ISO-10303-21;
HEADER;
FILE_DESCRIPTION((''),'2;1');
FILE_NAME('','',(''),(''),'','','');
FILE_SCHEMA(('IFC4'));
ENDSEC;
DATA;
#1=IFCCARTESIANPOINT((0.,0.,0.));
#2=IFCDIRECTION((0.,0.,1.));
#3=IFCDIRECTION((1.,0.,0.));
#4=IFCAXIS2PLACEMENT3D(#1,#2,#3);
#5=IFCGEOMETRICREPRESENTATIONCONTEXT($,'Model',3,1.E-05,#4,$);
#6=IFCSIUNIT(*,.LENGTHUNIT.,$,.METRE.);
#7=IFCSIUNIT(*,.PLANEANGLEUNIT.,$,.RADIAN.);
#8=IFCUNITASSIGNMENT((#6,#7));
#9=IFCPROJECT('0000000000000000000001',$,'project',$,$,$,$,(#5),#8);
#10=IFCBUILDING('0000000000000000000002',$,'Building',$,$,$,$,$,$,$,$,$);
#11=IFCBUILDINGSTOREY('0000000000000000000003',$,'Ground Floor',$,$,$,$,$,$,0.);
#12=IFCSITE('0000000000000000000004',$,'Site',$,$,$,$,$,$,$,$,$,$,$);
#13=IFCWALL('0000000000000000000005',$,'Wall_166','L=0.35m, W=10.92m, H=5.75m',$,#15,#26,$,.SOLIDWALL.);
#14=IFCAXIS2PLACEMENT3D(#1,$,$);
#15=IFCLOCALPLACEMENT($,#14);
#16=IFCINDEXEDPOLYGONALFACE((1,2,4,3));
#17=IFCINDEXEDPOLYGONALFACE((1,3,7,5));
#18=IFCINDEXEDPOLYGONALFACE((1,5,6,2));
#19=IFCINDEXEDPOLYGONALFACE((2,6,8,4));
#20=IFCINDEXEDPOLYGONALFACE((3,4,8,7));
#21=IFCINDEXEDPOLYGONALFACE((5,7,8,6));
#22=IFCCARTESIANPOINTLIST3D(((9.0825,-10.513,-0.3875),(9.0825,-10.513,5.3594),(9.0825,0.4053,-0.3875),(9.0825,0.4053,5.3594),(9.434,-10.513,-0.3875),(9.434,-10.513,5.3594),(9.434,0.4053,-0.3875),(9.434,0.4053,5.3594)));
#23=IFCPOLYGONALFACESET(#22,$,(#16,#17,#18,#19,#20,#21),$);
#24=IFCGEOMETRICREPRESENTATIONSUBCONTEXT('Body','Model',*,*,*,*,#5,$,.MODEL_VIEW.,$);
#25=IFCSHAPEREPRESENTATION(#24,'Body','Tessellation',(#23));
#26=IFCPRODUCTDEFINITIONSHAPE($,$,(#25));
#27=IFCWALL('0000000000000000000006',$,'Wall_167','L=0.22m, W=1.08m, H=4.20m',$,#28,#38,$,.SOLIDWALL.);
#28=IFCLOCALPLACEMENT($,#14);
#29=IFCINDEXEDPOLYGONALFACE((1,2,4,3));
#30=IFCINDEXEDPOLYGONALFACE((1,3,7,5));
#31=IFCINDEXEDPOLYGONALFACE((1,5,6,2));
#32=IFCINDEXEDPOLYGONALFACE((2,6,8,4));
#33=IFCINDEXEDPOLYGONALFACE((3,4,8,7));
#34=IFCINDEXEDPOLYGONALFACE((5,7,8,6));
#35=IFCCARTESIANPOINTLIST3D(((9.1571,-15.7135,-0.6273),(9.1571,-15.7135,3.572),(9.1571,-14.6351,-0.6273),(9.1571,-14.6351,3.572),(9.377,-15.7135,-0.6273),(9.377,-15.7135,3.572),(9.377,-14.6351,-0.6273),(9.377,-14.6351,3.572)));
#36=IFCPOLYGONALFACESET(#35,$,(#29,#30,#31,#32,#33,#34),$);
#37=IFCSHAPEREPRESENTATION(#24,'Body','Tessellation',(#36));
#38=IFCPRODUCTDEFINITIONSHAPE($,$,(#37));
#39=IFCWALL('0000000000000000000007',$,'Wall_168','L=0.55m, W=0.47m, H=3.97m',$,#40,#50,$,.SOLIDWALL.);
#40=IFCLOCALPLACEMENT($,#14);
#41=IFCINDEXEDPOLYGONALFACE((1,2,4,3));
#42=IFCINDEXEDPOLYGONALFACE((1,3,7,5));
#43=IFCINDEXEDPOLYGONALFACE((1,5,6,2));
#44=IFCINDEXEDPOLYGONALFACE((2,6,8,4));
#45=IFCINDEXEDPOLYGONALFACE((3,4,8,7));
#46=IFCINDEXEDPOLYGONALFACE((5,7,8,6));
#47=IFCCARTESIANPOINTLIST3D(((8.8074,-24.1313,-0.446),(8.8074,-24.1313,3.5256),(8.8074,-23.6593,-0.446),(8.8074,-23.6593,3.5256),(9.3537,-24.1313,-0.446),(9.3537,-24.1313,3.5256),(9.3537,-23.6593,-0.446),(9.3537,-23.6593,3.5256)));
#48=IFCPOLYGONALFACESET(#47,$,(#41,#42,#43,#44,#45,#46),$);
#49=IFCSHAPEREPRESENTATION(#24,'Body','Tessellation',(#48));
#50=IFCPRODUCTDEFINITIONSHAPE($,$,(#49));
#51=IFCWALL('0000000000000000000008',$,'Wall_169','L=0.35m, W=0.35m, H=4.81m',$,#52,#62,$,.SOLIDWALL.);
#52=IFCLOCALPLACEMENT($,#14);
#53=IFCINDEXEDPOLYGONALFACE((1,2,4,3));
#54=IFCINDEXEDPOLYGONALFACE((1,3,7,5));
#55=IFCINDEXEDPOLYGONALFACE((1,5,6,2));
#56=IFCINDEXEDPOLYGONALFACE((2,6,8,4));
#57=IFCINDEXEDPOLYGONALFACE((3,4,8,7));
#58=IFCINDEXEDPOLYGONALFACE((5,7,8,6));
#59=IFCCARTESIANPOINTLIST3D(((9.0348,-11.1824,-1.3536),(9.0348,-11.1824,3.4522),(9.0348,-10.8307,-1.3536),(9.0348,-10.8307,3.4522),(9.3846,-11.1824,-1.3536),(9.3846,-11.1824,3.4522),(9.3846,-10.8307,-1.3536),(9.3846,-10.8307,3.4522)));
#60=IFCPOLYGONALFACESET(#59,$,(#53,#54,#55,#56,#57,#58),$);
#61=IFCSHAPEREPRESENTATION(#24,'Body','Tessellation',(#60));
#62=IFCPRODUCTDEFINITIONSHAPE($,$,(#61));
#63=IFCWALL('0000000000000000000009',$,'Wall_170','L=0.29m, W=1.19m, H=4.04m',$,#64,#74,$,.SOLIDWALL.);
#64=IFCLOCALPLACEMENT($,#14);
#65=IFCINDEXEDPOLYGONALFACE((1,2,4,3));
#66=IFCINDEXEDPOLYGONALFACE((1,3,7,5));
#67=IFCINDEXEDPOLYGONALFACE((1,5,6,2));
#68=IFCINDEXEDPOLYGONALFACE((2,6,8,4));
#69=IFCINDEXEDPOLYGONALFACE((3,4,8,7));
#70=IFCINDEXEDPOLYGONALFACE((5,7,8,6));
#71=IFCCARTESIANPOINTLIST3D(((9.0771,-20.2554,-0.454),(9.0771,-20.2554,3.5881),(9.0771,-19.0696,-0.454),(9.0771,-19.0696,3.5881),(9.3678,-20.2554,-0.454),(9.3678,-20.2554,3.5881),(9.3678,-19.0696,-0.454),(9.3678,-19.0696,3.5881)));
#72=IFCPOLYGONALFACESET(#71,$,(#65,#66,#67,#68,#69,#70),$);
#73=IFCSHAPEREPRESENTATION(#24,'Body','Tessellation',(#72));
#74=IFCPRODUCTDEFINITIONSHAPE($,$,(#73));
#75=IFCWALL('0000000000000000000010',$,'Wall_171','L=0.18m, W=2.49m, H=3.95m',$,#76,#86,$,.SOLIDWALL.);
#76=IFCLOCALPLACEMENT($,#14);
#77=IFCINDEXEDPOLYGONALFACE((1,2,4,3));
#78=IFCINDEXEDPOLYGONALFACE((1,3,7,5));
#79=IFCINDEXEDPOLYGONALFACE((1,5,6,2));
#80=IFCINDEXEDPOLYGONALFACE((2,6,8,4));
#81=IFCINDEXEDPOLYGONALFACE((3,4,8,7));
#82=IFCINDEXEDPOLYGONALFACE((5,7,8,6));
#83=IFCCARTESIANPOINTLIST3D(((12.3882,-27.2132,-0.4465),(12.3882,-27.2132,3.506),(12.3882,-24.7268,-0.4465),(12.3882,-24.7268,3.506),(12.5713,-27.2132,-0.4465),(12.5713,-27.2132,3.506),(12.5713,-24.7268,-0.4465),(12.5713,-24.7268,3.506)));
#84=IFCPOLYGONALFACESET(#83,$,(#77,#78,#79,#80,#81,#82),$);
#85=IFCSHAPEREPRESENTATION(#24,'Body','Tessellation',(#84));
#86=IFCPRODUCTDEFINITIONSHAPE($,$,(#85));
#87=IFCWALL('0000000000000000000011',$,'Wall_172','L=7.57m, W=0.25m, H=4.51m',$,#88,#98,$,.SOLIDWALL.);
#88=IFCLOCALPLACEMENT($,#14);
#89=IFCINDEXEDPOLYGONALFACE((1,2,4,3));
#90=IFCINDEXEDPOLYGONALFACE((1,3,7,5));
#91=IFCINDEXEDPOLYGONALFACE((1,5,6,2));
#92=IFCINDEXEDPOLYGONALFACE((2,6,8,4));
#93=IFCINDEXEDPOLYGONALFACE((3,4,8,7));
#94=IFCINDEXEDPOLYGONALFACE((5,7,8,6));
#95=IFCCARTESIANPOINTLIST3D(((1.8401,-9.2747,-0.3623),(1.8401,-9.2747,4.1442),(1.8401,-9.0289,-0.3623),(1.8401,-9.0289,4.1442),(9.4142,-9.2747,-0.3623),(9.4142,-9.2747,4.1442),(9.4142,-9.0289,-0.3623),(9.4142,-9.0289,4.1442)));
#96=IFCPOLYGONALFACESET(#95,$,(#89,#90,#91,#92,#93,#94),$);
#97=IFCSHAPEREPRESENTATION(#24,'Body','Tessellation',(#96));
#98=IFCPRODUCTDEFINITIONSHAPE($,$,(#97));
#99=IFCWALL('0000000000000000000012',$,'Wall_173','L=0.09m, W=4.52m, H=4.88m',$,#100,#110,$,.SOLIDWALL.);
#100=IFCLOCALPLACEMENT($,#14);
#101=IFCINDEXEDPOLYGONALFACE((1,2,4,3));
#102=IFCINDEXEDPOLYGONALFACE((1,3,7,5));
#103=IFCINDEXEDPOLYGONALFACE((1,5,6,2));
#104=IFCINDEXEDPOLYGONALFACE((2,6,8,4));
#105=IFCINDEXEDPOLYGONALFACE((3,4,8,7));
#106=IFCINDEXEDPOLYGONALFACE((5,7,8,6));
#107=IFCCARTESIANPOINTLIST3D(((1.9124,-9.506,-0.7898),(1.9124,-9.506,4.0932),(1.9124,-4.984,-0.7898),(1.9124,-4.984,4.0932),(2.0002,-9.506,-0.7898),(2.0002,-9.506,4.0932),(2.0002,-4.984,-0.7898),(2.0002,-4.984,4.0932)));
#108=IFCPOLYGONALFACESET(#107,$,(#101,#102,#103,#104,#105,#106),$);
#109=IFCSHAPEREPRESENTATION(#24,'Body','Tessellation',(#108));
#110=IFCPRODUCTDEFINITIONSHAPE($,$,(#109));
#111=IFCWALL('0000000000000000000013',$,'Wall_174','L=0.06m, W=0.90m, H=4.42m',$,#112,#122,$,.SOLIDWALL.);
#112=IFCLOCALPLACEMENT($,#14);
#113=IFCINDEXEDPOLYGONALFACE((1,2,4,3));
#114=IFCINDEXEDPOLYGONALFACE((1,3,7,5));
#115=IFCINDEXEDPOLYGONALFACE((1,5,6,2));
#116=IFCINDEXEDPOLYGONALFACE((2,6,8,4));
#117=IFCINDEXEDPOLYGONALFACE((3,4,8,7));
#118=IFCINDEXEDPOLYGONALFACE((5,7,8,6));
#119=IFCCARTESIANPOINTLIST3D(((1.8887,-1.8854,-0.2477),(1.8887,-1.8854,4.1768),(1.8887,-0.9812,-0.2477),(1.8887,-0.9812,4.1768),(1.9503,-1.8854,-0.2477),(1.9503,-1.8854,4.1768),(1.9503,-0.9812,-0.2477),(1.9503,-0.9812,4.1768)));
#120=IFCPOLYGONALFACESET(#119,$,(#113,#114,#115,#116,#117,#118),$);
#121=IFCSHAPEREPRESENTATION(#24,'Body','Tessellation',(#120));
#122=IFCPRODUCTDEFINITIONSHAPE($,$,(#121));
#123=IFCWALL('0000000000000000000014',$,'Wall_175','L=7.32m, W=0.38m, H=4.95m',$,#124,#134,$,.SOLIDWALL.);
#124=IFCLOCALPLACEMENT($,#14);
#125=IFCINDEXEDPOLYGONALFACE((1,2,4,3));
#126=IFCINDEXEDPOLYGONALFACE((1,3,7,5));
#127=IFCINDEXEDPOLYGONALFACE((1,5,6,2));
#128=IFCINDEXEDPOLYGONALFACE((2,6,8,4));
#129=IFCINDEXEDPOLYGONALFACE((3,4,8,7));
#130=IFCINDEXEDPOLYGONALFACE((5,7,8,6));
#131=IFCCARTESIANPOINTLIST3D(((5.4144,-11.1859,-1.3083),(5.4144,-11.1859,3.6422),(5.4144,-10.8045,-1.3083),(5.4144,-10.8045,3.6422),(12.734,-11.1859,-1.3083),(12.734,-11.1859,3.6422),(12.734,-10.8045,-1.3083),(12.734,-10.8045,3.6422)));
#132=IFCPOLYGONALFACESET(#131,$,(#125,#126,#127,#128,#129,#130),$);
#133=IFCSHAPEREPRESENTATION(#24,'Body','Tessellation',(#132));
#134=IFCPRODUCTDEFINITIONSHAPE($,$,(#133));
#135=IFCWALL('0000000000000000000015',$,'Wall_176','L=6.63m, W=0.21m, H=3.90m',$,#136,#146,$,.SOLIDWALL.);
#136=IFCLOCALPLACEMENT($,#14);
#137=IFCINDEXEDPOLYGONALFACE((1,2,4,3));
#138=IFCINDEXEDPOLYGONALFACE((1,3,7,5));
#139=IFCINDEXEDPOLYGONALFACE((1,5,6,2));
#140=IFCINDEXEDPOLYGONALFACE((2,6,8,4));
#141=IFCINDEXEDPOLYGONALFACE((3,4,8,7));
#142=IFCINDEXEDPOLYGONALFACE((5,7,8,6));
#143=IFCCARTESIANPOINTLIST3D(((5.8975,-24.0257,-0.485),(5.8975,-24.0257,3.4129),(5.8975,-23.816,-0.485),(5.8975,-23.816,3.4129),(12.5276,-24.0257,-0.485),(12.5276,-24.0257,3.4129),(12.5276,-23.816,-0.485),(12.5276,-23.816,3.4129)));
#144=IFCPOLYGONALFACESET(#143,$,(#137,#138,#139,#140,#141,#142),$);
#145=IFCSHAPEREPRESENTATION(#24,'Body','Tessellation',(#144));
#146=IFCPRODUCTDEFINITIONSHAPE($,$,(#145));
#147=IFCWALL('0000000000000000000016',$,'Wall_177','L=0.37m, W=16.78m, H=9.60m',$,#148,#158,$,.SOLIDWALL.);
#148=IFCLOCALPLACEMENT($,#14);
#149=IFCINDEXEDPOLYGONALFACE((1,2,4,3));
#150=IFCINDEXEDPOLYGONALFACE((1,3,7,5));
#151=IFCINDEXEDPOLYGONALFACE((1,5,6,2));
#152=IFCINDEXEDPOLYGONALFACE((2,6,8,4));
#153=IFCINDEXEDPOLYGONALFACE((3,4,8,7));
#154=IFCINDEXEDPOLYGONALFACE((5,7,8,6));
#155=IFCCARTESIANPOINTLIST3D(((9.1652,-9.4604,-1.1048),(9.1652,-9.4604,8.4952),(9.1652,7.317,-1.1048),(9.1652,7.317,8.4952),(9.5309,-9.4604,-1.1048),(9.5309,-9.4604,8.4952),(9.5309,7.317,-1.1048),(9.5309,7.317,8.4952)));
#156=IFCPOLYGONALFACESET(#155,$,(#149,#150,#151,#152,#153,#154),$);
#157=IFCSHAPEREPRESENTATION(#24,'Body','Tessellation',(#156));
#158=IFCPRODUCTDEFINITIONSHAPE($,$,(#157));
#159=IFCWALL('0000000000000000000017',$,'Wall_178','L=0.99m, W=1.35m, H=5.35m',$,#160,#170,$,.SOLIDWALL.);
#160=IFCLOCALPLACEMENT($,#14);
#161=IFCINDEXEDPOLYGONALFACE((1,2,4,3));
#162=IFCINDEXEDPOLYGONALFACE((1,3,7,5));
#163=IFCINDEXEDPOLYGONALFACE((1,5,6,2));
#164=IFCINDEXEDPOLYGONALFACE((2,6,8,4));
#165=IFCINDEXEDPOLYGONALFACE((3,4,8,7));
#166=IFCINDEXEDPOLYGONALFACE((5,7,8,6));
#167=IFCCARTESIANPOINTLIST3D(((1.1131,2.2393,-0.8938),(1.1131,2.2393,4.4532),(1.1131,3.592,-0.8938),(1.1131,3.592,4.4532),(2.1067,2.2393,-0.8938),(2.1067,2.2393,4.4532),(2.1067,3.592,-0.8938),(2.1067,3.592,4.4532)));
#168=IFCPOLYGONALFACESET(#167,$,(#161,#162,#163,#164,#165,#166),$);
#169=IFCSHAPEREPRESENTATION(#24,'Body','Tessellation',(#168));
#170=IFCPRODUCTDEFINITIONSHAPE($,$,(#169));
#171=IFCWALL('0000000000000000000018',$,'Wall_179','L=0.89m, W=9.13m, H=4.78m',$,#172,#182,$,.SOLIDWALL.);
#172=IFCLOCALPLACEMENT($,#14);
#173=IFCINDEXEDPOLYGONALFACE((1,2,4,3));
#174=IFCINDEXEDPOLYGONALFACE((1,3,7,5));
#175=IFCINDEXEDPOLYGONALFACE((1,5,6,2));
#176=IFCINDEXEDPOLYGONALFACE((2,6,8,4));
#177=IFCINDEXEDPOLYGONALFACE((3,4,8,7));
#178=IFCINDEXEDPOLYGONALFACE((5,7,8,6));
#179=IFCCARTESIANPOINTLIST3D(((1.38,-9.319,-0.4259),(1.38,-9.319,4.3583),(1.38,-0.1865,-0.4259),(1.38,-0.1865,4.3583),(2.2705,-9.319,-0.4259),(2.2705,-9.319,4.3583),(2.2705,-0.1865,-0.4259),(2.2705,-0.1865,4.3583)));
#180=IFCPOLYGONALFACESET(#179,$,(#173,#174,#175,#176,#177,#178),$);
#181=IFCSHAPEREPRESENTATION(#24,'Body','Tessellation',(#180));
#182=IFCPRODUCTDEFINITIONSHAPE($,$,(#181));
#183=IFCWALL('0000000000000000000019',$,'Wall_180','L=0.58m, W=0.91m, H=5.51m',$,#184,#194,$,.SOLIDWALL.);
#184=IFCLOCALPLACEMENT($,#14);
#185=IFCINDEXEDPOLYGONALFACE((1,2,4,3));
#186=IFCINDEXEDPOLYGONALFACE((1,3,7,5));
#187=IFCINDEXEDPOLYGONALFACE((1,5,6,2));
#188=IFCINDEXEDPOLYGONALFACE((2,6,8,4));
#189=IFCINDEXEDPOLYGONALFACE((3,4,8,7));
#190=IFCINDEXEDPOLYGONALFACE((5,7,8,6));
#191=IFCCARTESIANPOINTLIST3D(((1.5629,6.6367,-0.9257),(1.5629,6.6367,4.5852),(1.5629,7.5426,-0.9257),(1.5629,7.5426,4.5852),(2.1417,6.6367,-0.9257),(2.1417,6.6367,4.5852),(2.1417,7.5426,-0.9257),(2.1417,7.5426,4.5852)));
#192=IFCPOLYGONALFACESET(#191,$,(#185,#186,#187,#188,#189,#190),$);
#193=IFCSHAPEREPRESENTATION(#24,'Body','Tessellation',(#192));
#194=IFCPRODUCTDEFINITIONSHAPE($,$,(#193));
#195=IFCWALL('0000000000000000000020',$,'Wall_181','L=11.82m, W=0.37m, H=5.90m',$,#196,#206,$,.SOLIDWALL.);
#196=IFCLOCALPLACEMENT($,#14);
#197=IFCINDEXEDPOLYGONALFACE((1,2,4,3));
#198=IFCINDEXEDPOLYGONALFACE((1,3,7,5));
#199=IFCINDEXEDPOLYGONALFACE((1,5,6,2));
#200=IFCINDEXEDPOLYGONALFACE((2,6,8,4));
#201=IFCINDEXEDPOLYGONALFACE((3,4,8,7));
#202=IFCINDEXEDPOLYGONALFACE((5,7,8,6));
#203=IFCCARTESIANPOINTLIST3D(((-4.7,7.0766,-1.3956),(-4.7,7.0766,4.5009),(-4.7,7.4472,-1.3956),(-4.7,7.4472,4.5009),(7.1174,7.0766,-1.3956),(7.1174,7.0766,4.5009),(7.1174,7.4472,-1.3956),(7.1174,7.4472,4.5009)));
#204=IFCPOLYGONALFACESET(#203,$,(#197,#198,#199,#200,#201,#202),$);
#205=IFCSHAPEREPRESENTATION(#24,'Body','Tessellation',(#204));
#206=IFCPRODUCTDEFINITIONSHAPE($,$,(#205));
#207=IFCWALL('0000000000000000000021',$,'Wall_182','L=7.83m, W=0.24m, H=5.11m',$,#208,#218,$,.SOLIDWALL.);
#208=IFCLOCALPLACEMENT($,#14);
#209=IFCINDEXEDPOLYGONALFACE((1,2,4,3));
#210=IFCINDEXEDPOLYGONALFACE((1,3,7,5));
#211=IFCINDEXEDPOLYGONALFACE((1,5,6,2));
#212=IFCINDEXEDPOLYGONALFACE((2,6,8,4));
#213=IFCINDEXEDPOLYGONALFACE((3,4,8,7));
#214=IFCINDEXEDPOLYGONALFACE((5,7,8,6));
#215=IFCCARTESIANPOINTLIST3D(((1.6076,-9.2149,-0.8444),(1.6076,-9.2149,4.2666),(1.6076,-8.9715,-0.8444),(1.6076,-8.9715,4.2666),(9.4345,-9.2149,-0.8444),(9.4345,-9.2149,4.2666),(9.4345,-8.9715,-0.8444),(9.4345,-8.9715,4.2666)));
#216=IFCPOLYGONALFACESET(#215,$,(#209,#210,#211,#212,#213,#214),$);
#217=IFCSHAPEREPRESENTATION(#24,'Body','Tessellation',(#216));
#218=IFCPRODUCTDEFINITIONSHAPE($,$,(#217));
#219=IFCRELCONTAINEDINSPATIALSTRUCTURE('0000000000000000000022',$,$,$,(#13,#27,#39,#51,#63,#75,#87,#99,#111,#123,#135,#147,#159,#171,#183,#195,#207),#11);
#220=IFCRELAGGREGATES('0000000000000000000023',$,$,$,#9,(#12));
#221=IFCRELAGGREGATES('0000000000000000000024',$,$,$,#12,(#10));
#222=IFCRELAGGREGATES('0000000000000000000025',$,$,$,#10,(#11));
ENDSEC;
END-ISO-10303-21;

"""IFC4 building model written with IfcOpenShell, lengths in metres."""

from ifc_helpers import new_model, si_unit, frame, origin_with_axes, origin_2d, context, subcontext, project, spatial, rectangle, extrude, element, save


model = new_model("IFC4")

# Units and contexts
model_context = context("Model", 3, precision=1e-05, world=origin_with_axes())
body_context = subcontext(model_context, "Body", "Model", "MODEL_VIEW")
ifc_project = project(units=[si_unit("LENGTHUNIT", "METRE"), si_unit("PLANEANGLEUNIT", "RADIAN")], contexts=[model_context])

# Site, building, storey
site = spatial("IfcSite", under=ifc_project, Name="Site")
building = spatial("IfcBuilding", under=site, Name="Building")
storey = spatial("IfcBuildingStorey", under=building, Name="Ground Floor", Elevation=0.0)

# Walls
element("IfcWall", 1, inside=storey, Name="Wall_166", Description="L=0.35m, W=10.92m, H=5.75m", PredefinedType="SOLIDWALL", context=body_context, shape_type="SweptSolid", body=[
    extrude(rectangle(XDim=0.3516, YDim=10.9184, at=origin_2d()), frame((9.2583, -5.0538, -0.3875), z_axis=(0.0, 0.0, 1.0), x_axis=(1.0, 0.0, 0.0)), (0.0, 0.0, 1.0), 5.747),
])
element("IfcWall", 2, inside=storey, Name="Wall_167", Description="L=0.22m, W=1.08m, H=4.20m", PredefinedType="SOLIDWALL", context=body_context, shape_type="SweptSolid", body=[
    extrude(rectangle(XDim=0.2199, YDim=1.0784, at=origin_2d()), frame((9.267, -15.1743, -0.6273), z_axis=(0.0, 0.0, 1.0), x_axis=(1.0, 0.0, 0.0)), (0.0, 0.0, 1.0), 4.1993),
])
element("IfcWall", 3, inside=storey, Name="Wall_168", Description="L=0.55m, W=0.47m, H=3.97m", PredefinedType="SOLIDWALL", context=body_context, shape_type="SweptSolid", body=[
    extrude(rectangle(XDim=0.5463, YDim=0.472, at=origin_2d()), frame((9.0806, -23.8953, -0.446), z_axis=(0.0, 0.0, 1.0), x_axis=(1.0, 0.0, 0.0)), (0.0, 0.0, 1.0), 3.9716),
])
element("IfcWall", 4, inside=storey, Name="Wall_169", Description="L=0.35m, W=0.35m, H=4.81m", PredefinedType="SOLIDWALL", context=body_context, shape_type="SweptSolid", body=[
    extrude(rectangle(XDim=0.3497, YDim=0.3517, at=origin_2d()), frame((9.2097, -11.0066, -1.3536), z_axis=(0.0, 0.0, 1.0), x_axis=(1.0, 0.0, 0.0)), (0.0, 0.0, 1.0), 4.8058),
])
element("IfcWall", 5, inside=storey, Name="Wall_170", Description="L=0.29m, W=1.19m, H=4.04m", PredefinedType="SOLIDWALL", context=body_context, shape_type="SweptSolid", body=[
    extrude(rectangle(XDim=0.2907, YDim=1.1858, at=origin_2d()), frame((9.2224, -19.6625, -0.454), z_axis=(0.0, 0.0, 1.0), x_axis=(1.0, 0.0, 0.0)), (0.0, 0.0, 1.0), 4.0421),
])
element("IfcWall", 6, inside=storey, Name="Wall_171", Description="L=0.18m, W=2.49m, H=3.95m", PredefinedType="SOLIDWALL", context=body_context, shape_type="SweptSolid", body=[
    extrude(rectangle(XDim=0.1831, YDim=2.4865, at=origin_2d()), frame((12.4797, -25.97, -0.4465), z_axis=(0.0, 0.0, 1.0), x_axis=(1.0, 0.0, 0.0)), (0.0, 0.0, 1.0), 3.9525),
])
element("IfcWall", 7, inside=storey, Name="Wall_172", Description="L=7.57m, W=0.25m, H=4.51m", PredefinedType="SOLIDWALL", context=body_context, shape_type="SweptSolid", body=[
    extrude(rectangle(XDim=7.574, YDim=0.2458, at=origin_2d()), frame((5.6272, -9.1518, -0.3623), z_axis=(0.0, 0.0, 1.0), x_axis=(1.0, 0.0, 0.0)), (0.0, 0.0, 1.0), 4.5066),
])
element("IfcWall", 8, inside=storey, Name="Wall_173", Description="L=0.09m, W=4.52m, H=4.88m", PredefinedType="SOLIDWALL", context=body_context, shape_type="SweptSolid", body=[
    extrude(rectangle(XDim=0.0879, YDim=4.522, at=origin_2d()), frame((1.9563, -7.245, -0.7898), z_axis=(0.0, 0.0, 1.0), x_axis=(1.0, 0.0, 0.0)), (0.0, 0.0, 1.0), 4.883),
])
element("IfcWall", 9, inside=storey, Name="Wall_174", Description="L=0.06m, W=0.90m, H=4.42m", PredefinedType="SOLIDWALL", context=body_context, shape_type="SweptSolid", body=[
    extrude(rectangle(XDim=0.0616, YDim=0.9042, at=origin_2d()), frame((1.9195, -1.4333, -0.2477), z_axis=(0.0, 0.0, 1.0), x_axis=(1.0, 0.0, 0.0)), (0.0, 0.0, 1.0), 4.4245),
])
element("IfcWall", 10, inside=storey, Name="Wall_175", Description="L=7.32m, W=0.38m, H=4.95m", PredefinedType="SOLIDWALL", context=body_context, shape_type="SweptSolid", body=[
    extrude(rectangle(XDim=7.3196, YDim=0.3814, at=origin_2d()), frame((9.0742, -10.9952, -1.3083), z_axis=(0.0, 0.0, 1.0), x_axis=(1.0, 0.0, 0.0)), (0.0, 0.0, 1.0), 4.9505),
])
element("IfcWall", 11, inside=storey, Name="Wall_176", Description="L=6.63m, W=0.21m, H=3.90m", PredefinedType="SOLIDWALL", context=body_context, shape_type="SweptSolid", body=[
    extrude(rectangle(XDim=6.6301, YDim=0.2098, at=origin_2d()), frame((9.2125, -23.9209, -0.485), z_axis=(0.0, 0.0, 1.0), x_axis=(1.0, 0.0, 0.0)), (0.0, 0.0, 1.0), 3.8979),
])
element("IfcWall", 12, inside=storey, Name="Wall_177", Description="L=0.37m, W=16.78m, H=9.60m", PredefinedType="SOLIDWALL", context=body_context, shape_type="SweptSolid", body=[
    extrude(rectangle(XDim=0.3657, YDim=16.7774, at=origin_2d()), frame((9.348, -1.0717, -1.1048), z_axis=(0.0, 0.0, 1.0), x_axis=(1.0, 0.0, 0.0)), (0.0, 0.0, 1.0), 9.6),
])
element("IfcWall", 13, inside=storey, Name="Wall_178", Description="L=0.99m, W=1.35m, H=5.35m", PredefinedType="SOLIDWALL", context=body_context, shape_type="SweptSolid", body=[
    extrude(rectangle(XDim=0.9935, YDim=1.3527, at=origin_2d()), frame((1.6099, 2.9157, -0.8938), z_axis=(0.0, 0.0, 1.0), x_axis=(1.0, 0.0, 0.0)), (0.0, 0.0, 1.0), 5.347),
])
element("IfcWall", 14, inside=storey, Name="Wall_179", Description="L=0.89m, W=9.13m, H=4.78m", PredefinedType="SOLIDWALL", context=body_context, shape_type="SweptSolid", body=[
    extrude(rectangle(XDim=0.8905, YDim=9.1325, at=origin_2d()), frame((1.8252, -4.7527, -0.4259), z_axis=(0.0, 0.0, 1.0), x_axis=(1.0, 0.0, 0.0)), (0.0, 0.0, 1.0), 4.7842),
])
element("IfcWall", 15, inside=storey, Name="Wall_180", Description="L=0.58m, W=0.91m, H=5.51m", PredefinedType="SOLIDWALL", context=body_context, shape_type="SweptSolid", body=[
    extrude(rectangle(XDim=0.5788, YDim=0.9059, at=origin_2d()), frame((1.8523, 7.0896, -0.9257), z_axis=(0.0, 0.0, 1.0), x_axis=(1.0, 0.0, 0.0)), (0.0, 0.0, 1.0), 5.5109),
])
element("IfcWall", 16, inside=storey, Name="Wall_181", Description="L=11.82m, W=0.37m, H=5.90m", PredefinedType="SOLIDWALL", context=body_context, shape_type="SweptSolid", body=[
    extrude(rectangle(XDim=11.8173, YDim=0.3706, at=origin_2d()), frame((1.2087, 7.2619, -1.3956), z_axis=(0.0, 0.0, 1.0), x_axis=(1.0, 0.0, 0.0)), (0.0, 0.0, 1.0), 5.8965),
])
element("IfcWall", 17, inside=storey, Name="Wall_182", Description="L=7.83m, W=0.24m, H=5.11m", PredefinedType="SOLIDWALL", context=body_context, shape_type="SweptSolid", body=[
    extrude(rectangle(XDim=7.8269, YDim=0.2435, at=origin_2d()), frame((5.521, -9.0932, -0.8444), z_axis=(0.0, 0.0, 1.0), x_axis=(1.0, 0.0, 0.0)), (0.0, 0.0, 1.0), 5.111),
])

save(model, "model.ifc")
